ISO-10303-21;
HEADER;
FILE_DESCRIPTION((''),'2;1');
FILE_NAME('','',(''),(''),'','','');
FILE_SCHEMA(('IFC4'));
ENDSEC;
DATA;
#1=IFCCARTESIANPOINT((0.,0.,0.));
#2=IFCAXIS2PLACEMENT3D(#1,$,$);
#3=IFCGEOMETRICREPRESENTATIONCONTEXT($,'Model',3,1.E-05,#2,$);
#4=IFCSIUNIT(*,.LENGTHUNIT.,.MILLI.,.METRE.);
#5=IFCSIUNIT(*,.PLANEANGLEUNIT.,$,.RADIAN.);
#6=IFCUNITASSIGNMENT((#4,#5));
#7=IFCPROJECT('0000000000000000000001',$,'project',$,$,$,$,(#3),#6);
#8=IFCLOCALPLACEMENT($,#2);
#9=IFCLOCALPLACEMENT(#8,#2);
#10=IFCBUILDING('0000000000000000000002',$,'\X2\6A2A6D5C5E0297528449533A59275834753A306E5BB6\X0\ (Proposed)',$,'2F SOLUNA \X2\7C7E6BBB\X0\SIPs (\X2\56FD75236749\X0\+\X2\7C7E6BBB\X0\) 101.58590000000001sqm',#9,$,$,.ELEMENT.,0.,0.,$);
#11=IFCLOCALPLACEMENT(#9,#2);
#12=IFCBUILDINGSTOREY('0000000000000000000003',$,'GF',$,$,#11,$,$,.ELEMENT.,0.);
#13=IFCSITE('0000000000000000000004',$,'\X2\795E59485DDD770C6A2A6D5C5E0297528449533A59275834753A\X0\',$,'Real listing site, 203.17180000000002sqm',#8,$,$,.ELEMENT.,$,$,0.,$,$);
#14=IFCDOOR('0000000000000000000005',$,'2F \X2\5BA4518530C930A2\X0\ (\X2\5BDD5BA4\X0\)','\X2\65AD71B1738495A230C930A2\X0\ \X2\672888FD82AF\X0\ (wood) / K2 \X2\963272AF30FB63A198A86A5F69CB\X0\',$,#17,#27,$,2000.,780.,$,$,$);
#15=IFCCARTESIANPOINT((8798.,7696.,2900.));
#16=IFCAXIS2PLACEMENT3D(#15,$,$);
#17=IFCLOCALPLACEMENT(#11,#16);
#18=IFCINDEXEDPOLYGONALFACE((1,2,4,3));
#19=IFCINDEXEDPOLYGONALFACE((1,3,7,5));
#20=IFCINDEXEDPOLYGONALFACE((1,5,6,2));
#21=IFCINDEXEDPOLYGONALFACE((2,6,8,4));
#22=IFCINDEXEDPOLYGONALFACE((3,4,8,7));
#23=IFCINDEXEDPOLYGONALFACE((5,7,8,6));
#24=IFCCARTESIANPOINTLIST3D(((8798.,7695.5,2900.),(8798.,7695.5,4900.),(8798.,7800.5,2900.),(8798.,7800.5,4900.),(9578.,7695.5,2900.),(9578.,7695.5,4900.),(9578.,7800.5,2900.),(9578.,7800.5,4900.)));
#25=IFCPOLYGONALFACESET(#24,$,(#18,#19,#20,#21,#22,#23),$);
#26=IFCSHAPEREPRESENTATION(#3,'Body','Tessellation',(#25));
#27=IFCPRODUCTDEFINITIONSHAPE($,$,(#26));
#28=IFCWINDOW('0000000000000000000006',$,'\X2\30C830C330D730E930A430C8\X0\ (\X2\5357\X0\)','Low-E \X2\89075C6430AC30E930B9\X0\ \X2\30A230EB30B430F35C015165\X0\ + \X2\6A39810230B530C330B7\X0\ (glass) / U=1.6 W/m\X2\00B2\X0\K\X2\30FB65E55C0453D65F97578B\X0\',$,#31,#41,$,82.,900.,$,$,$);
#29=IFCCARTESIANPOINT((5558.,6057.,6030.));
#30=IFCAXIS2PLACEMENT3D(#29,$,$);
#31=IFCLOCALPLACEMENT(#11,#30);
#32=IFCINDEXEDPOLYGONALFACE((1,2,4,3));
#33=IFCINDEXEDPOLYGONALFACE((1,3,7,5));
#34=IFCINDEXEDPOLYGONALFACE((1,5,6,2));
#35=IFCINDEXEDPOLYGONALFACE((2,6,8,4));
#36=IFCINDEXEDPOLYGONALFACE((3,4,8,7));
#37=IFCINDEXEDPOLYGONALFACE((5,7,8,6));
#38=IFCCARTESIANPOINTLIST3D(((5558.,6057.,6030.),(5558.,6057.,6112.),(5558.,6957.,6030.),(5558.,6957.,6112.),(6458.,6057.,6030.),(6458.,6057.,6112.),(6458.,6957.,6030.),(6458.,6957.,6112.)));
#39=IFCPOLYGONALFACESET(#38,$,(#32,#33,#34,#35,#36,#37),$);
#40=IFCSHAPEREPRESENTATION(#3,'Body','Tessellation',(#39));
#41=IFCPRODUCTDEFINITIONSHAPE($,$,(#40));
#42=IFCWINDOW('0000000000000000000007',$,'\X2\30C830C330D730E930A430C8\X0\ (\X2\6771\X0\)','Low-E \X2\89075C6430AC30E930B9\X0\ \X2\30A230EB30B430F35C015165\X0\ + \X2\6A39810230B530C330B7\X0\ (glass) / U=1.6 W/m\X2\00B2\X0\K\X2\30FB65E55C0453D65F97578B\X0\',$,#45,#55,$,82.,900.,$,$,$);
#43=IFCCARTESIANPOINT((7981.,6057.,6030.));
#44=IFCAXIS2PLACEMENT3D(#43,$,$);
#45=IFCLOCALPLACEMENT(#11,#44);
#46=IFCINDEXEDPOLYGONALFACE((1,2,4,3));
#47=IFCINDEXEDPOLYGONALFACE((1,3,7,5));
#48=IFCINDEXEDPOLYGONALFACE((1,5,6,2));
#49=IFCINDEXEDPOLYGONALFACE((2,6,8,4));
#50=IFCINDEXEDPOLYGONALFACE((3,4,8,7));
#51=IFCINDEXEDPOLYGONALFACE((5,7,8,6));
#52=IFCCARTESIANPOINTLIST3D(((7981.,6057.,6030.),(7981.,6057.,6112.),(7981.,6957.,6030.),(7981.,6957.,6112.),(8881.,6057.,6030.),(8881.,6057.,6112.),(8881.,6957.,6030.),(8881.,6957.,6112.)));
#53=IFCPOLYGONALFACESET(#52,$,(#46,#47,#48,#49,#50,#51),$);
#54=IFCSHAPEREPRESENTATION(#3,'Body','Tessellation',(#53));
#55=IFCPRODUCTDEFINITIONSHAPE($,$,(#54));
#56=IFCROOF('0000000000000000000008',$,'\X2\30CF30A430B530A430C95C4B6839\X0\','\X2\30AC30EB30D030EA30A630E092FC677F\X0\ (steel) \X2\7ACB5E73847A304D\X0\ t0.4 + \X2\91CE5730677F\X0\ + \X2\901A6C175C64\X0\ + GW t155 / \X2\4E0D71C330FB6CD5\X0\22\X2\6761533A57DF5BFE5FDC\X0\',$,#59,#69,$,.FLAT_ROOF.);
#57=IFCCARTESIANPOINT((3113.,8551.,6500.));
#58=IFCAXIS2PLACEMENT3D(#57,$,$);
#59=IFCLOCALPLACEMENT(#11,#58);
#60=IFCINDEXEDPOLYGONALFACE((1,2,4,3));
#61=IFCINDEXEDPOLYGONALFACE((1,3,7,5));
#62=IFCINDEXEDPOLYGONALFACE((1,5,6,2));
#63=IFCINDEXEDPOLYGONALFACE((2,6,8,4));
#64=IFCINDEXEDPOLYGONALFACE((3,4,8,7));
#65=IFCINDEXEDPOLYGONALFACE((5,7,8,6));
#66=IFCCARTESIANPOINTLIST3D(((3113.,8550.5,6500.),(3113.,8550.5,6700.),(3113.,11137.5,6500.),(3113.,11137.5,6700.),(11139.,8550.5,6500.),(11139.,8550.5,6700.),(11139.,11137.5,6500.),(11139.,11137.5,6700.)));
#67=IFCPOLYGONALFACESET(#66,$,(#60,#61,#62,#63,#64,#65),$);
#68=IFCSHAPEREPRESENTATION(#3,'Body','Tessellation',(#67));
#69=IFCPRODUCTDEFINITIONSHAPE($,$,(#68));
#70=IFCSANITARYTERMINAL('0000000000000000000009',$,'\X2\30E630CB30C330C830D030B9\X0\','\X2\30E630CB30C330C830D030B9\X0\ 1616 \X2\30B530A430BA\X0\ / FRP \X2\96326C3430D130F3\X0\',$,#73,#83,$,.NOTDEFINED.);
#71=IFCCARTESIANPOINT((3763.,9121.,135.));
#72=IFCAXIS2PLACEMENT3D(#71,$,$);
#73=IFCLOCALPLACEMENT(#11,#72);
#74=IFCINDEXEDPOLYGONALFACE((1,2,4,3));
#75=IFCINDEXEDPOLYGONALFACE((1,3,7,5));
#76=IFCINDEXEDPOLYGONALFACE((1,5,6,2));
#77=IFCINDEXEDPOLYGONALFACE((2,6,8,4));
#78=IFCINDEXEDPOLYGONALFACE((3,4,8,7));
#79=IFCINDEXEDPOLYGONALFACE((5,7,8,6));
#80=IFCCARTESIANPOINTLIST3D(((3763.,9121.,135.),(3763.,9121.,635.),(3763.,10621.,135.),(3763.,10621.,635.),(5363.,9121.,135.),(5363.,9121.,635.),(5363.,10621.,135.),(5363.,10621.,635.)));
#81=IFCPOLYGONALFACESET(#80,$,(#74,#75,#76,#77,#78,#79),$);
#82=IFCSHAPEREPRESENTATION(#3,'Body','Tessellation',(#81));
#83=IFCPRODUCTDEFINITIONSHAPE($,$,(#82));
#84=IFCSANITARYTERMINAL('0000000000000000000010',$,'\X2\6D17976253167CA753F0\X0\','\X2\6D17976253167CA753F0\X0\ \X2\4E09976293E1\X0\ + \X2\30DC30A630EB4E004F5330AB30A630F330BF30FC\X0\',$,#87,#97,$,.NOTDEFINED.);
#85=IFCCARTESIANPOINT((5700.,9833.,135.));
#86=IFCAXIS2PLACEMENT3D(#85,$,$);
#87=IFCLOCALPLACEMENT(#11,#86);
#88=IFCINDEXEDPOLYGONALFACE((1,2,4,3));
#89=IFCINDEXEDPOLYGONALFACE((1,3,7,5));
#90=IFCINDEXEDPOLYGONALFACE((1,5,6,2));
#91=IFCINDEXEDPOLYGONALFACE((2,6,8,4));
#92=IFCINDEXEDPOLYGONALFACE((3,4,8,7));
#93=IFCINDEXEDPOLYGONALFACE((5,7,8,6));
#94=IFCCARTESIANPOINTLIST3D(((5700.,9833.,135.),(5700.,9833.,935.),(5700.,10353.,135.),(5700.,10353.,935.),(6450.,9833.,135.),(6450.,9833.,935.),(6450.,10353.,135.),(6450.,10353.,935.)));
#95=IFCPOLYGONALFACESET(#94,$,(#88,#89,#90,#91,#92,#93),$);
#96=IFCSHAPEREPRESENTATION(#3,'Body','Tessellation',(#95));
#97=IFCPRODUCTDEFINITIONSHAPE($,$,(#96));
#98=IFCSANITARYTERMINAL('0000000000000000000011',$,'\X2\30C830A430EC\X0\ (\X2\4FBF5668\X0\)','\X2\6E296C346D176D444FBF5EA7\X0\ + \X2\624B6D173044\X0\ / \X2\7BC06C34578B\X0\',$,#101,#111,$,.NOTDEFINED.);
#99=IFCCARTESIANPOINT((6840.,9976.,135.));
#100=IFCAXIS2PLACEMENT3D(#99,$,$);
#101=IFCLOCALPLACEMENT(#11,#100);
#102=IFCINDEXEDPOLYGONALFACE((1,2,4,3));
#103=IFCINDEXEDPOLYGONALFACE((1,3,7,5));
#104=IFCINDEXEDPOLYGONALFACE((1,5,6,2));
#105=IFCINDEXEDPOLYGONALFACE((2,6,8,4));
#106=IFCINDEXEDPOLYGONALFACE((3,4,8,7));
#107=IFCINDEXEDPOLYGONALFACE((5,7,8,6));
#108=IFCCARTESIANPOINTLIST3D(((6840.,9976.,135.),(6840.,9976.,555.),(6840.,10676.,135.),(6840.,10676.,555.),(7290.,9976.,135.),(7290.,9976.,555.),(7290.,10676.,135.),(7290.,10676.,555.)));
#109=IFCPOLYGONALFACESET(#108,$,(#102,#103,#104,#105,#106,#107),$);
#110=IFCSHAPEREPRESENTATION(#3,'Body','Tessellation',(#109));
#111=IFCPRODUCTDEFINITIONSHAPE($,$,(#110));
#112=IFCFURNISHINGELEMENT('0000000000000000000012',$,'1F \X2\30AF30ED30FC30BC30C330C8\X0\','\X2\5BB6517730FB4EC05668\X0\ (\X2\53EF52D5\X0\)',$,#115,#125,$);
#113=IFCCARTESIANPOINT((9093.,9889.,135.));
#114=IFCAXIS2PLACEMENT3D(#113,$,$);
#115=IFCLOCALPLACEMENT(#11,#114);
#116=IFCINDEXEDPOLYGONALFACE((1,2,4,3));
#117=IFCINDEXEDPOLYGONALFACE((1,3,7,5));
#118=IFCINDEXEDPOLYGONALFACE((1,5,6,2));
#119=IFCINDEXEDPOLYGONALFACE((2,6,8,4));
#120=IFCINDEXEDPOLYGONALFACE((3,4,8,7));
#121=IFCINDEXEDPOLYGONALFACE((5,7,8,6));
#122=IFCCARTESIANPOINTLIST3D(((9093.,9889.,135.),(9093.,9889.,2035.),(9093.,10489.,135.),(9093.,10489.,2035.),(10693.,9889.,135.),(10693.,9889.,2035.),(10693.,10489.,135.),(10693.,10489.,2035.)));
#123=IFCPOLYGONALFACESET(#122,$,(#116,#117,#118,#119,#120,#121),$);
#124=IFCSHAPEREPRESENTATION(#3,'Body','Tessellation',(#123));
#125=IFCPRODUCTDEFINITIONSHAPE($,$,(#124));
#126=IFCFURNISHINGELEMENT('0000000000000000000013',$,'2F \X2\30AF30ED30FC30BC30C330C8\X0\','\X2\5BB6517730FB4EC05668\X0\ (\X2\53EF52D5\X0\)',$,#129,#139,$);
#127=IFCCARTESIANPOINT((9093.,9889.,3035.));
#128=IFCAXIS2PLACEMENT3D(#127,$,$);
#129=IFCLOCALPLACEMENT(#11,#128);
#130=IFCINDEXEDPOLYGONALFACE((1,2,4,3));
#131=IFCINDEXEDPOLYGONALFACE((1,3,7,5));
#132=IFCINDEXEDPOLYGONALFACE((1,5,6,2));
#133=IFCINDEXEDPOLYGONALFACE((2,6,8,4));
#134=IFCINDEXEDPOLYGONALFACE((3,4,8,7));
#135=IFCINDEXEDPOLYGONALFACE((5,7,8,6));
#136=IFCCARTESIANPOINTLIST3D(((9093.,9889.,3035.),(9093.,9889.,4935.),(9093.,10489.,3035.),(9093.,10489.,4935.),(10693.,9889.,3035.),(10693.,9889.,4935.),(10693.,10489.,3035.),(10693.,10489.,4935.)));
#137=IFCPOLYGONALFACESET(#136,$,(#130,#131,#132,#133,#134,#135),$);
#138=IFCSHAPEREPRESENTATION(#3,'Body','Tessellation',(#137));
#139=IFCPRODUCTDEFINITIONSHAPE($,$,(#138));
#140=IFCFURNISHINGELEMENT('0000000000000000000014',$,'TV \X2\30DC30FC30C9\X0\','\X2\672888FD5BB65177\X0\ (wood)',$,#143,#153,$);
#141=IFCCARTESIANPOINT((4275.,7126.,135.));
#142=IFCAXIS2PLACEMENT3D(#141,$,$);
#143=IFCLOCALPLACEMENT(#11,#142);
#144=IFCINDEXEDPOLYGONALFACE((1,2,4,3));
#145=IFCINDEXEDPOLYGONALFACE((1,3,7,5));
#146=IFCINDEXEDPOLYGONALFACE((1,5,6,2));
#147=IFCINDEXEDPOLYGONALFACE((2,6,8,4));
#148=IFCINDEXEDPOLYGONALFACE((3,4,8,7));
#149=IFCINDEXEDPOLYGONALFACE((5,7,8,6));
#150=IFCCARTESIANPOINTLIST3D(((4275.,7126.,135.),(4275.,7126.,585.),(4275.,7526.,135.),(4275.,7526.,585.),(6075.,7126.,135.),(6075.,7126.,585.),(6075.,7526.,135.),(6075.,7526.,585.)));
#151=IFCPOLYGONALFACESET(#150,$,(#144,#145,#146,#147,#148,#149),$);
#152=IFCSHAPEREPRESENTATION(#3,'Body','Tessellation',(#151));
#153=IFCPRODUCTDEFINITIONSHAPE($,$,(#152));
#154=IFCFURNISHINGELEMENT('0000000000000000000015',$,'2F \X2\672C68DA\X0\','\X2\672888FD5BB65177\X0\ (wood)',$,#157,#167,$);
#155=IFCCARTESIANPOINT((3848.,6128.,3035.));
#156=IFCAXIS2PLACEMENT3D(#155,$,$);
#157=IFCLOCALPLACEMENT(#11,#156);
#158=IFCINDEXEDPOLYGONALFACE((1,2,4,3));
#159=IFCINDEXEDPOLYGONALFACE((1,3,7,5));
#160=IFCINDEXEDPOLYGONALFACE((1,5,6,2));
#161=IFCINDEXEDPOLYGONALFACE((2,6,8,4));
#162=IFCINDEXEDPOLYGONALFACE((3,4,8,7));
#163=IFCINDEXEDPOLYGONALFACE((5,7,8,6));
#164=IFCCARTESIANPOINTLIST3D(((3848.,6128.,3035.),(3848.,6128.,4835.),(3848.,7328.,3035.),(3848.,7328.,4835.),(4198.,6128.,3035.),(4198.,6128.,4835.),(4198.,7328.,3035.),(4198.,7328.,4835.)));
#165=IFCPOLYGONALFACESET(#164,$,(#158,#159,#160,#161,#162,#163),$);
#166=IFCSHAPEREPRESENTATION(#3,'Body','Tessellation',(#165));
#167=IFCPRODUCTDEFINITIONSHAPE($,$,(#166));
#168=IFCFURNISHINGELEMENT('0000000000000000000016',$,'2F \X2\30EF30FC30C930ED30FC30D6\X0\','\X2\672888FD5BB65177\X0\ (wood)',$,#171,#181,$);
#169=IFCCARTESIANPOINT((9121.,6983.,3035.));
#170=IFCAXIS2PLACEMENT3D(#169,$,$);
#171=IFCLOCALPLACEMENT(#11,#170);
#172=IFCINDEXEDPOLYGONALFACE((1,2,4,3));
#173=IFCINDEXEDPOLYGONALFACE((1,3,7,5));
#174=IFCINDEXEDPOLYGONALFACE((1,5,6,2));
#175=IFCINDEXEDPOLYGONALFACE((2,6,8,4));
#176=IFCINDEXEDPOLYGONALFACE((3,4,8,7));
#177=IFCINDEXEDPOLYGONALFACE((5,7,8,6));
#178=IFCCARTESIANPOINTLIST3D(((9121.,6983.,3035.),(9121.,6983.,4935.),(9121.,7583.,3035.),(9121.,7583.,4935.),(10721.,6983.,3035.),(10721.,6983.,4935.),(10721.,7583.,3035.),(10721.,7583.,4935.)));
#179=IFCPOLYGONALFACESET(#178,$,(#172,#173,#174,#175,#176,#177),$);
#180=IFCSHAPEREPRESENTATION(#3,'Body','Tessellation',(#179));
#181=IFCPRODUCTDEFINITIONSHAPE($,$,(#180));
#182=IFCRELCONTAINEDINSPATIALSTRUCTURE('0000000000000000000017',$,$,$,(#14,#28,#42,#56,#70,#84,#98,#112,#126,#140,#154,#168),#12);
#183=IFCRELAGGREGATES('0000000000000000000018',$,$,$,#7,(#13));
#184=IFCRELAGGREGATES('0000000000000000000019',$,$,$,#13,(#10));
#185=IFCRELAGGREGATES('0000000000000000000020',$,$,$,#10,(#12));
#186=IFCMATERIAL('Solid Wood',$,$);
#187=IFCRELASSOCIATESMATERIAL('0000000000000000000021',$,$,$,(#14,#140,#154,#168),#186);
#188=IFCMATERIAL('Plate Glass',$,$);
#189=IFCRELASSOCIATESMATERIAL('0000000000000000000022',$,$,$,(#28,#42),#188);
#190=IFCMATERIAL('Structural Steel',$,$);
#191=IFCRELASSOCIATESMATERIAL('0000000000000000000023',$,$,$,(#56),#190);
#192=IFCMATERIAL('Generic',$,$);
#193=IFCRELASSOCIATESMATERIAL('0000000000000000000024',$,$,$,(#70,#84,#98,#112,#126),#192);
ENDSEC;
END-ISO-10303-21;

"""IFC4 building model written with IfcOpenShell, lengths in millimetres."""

from ifc_helpers import new_model, si_unit, frame, frame_2d, origin, place, context, project, spatial, rectangle, extrude, material, element, save


model = new_model("IFC4")

# Units and contexts
model_context = context("Model", 3, precision=1e-05, world=origin())
ifc_project = project(units=[si_unit("LENGTHUNIT", "METRE", prefix="MILLI"), si_unit("PLANEANGLEUNIT", "RADIAN")], contexts=[model_context])

# Site, building, storey
site_placement = place(None, origin())
site = spatial("IfcSite", under=ifc_project, at=site_placement, Name="神奈川県横浜市青葉区大場町", ObjectType="Real listing site, 203.17180000000002sqm", CompositionType="ELEMENT", RefElevation=0.0)
building_placement = place(site_placement, origin())
building = spatial("IfcBuilding", under=site, at=building_placement, Name="横浜市青葉区大場町の家 (Proposed)", ObjectType="2F SOLUNA 籾殻SIPs (国産杉+籾殻) 101.58590000000001sqm", CompositionType="ELEMENT", ElevationOfRefHeight=0.0, ElevationOfTerrain=0.0)
storey_placement = place(building_placement, origin())
storey = spatial("IfcBuildingStorey", under=building, at=storey_placement, Name="GF", CompositionType="ELEMENT", Elevation=0.0)

# Shared definitions
ifc_material_1 = material(Name="Solid Wood")
ifc_material_2 = material(Name="Plate Glass")

# Door
door_1_placement = place(storey_placement, frame((8798.0, 7696.0, 2900.0)))
element("IfcDoor", 1, at=door_1_placement, inside=storey, material=ifc_material_1, Name="2F 室内ドア (寝室)", Description="断熱玄関ドア 木製芯 (wood) / K2 防犯・採風機構", OverallHeight=2000.0, OverallWidth=780.0, context=model_context, shape_type="SweptSolid", body=[
    extrude(rectangle(XDim=780.0, YDim=105.0, at=frame_2d((390.0, 52.0))), frame((8798.0, 7696.0, 2900.0)), (0.0, 0.0, 1.0), 2000.0),
])

# Windows
window_1_placement = place(storey_placement, frame((5558.0, 6057.0, 6030.0)))
element("IfcWindow", 2, at=window_1_placement, inside=storey, material=ifc_material_2, Name="トップライト (南)", Description="Low-E 複層ガラス アルゴン封入 + 樹脂サッシ (glass) / U=1.6 W/m²K・日射取得型", OverallHeight=82.0, OverallWidth=900.0, context=model_context, shape_type="SweptSolid", body=[
    extrude(rectangle(XDim=900.0, YDim=900.0, at=frame_2d((450.0, 450.0))), frame((5558.0, 6057.0, 6030.0)), (0.0, 0.0, 1.0), 82.0),
])
window_2_placement = place(storey_placement, frame((7981.0, 6057.0, 6030.0)))
element("IfcWindow", 3, at=window_2_placement, inside=storey, material=ifc_material_2, Name="トップライト (東)", Description="Low-E 複層ガラス アルゴン封入 + 樹脂サッシ (glass) / U=1.6 W/m²K・日射取得型", OverallHeight=82.0, OverallWidth=900.0, context=model_context, shape_type="SweptSolid", body=[
    extrude(rectangle(XDim=900.0, YDim=900.0, at=frame_2d((450.0, 450.0))), frame((7981.0, 6057.0, 6030.0)), (0.0, 0.0, 1.0), 82.0),
])

# Roof
ifc_material_3 = material(Name="Structural Steel")
roof_placement = place(storey_placement, frame((3113.0, 8551.0, 6500.0)))
element("IfcRoof", 4, at=roof_placement, inside=storey, material=ifc_material_3, Name="ハイサイド屋根", Description="ガルバリウム鋼板 (steel) 立平葺き t0.4 + 野地板 + 通気層 + GW t155 / 不燃・法22条区域対応", PredefinedType="FLAT_ROOF", context=model_context, shape_type="SweptSolid", body=[
    extrude(rectangle(XDim=8026.0, YDim=2587.0, at=frame_2d((4013.0, 1293.0))), frame((3113.0, 8551.0, 6500.0)), (0.0, 0.0, 1.0), 200.0),
])

# Sanitary terminals
ifc_material_4 = material(Name="Generic")
sanitary_terminal_1_placement = place(storey_placement, frame((3763.0, 9121.0, 135.0)))
element("IfcSanitaryTerminal", 5, at=sanitary_terminal_1_placement, inside=storey, material=ifc_material_4, Name="ユニットバス", Description="ユニットバス 1616 サイズ / FRP 防水パン", PredefinedType="NOTDEFINED", context=model_context, shape_type="SweptSolid", body=[
    extrude(rectangle(XDim=1600.0, YDim=1500.0, at=frame_2d((800.0, 750.0))), frame((3763.0, 9121.0, 135.0)), (0.0, 0.0, 1.0), 500.0),
])
sanitary_terminal_2_placement = place(storey_placement, frame((5700.0, 9833.0, 135.0)))
element("IfcSanitaryTerminal", 6, at=sanitary_terminal_2_placement, inside=storey, material=ifc_material_4, Name="洗面化粧台", Description="洗面化粧台 三面鏡 + ボウル一体カウンター", PredefinedType="NOTDEFINED", context=model_context, shape_type="SweptSolid", body=[
    extrude(rectangle(XDim=750.0, YDim=520.0, at=frame_2d((375.0, 260.0))), frame((5700.0, 9833.0, 135.0)), (0.0, 0.0, 1.0), 800.0),
])
sanitary_terminal_3_placement = place(storey_placement, frame((6840.0, 9976.0, 135.0)))
element("IfcSanitaryTerminal", 7, at=sanitary_terminal_3_placement, inside=storey, material=ifc_material_4, Name="トイレ (便器)", Description="温水洗浄便座 + 手洗い / 節水型", PredefinedType="NOTDEFINED", context=model_context, shape_type="SweptSolid", body=[
    extrude(rectangle(XDim=450.0, YDim=700.0, at=frame_2d((225.0, 350.0))), frame((6840.0, 9976.0, 135.0)), (0.0, 0.0, 1.0), 420.0),
])

# Furnishing elements
furnishing_1_placement = place(storey_placement, frame((9093.0, 9889.0, 135.0)))
element("IfcFurnishingElement", 8, at=furnishing_1_placement, inside=storey, material=ifc_material_4, Name="1F クローゼット", Description="家具・什器 (可動)", context=model_context, shape_type="SweptSolid", body=[
    extrude(rectangle(XDim=1600.0, YDim=600.0, at=frame_2d((800.0, 300.0))), frame((9093.0, 9889.0, 135.0)), (0.0, 0.0, 1.0), 1900.0),
])
furnishing_2_placement = place(storey_placement, frame((9093.0, 9889.0, 3035.0)))
element("IfcFurnishingElement", 9, at=furnishing_2_placement, inside=storey, material=ifc_material_4, Name="2F クローゼット", Description="家具・什器 (可動)", context=model_context, shape_type="SweptSolid", body=[
    extrude(rectangle(XDim=1600.0, YDim=600.0, at=frame_2d((800.0, 300.0))), frame((9093.0, 9889.0, 3035.0)), (0.0, 0.0, 1.0), 1900.0),
])
furnishing_3_placement = place(storey_placement, frame((4275.0, 7126.0, 135.0)))
element("IfcFurnishingElement", 10, at=furnishing_3_placement, inside=storey, material=ifc_material_1, Name="TV ボード", Description="木製家具 (wood)", context=model_context, shape_type="SweptSolid", body=[
    extrude(rectangle(XDim=1800.0, YDim=400.0, at=frame_2d((900.0, 200.0))), frame((4275.0, 7126.0, 135.0)), (0.0, 0.0, 1.0), 450.0),
])
furnishing_4_placement = place(storey_placement, frame((3848.0, 6128.0, 3035.0)))
element("IfcFurnishingElement", 11, at=furnishing_4_placement, inside=storey, material=ifc_material_1, Name="2F 本棚", Description="木製家具 (wood)", context=model_context, shape_type="SweptSolid", body=[
    extrude(rectangle(XDim=350.0, YDim=1200.0, at=frame_2d((175.0, 600.0))), frame((3848.0, 6128.0, 3035.0)), (0.0, 0.0, 1.0), 1800.0),
])
furnishing_5_placement = place(storey_placement, frame((9121.0, 6983.0, 3035.0)))
element("IfcFurnishingElement", 12, at=furnishing_5_placement, inside=storey, material=ifc_material_1, Name="2F ワードローブ", Description="木製家具 (wood)", context=model_context, shape_type="SweptSolid", body=[
    extrude(rectangle(XDim=1600.0, YDim=600.0, at=frame_2d((800.0, 300.0))), frame((9121.0, 6983.0, 3035.0)), (0.0, 0.0, 1.0), 1900.0),
])

save(model, "model.ifc")
